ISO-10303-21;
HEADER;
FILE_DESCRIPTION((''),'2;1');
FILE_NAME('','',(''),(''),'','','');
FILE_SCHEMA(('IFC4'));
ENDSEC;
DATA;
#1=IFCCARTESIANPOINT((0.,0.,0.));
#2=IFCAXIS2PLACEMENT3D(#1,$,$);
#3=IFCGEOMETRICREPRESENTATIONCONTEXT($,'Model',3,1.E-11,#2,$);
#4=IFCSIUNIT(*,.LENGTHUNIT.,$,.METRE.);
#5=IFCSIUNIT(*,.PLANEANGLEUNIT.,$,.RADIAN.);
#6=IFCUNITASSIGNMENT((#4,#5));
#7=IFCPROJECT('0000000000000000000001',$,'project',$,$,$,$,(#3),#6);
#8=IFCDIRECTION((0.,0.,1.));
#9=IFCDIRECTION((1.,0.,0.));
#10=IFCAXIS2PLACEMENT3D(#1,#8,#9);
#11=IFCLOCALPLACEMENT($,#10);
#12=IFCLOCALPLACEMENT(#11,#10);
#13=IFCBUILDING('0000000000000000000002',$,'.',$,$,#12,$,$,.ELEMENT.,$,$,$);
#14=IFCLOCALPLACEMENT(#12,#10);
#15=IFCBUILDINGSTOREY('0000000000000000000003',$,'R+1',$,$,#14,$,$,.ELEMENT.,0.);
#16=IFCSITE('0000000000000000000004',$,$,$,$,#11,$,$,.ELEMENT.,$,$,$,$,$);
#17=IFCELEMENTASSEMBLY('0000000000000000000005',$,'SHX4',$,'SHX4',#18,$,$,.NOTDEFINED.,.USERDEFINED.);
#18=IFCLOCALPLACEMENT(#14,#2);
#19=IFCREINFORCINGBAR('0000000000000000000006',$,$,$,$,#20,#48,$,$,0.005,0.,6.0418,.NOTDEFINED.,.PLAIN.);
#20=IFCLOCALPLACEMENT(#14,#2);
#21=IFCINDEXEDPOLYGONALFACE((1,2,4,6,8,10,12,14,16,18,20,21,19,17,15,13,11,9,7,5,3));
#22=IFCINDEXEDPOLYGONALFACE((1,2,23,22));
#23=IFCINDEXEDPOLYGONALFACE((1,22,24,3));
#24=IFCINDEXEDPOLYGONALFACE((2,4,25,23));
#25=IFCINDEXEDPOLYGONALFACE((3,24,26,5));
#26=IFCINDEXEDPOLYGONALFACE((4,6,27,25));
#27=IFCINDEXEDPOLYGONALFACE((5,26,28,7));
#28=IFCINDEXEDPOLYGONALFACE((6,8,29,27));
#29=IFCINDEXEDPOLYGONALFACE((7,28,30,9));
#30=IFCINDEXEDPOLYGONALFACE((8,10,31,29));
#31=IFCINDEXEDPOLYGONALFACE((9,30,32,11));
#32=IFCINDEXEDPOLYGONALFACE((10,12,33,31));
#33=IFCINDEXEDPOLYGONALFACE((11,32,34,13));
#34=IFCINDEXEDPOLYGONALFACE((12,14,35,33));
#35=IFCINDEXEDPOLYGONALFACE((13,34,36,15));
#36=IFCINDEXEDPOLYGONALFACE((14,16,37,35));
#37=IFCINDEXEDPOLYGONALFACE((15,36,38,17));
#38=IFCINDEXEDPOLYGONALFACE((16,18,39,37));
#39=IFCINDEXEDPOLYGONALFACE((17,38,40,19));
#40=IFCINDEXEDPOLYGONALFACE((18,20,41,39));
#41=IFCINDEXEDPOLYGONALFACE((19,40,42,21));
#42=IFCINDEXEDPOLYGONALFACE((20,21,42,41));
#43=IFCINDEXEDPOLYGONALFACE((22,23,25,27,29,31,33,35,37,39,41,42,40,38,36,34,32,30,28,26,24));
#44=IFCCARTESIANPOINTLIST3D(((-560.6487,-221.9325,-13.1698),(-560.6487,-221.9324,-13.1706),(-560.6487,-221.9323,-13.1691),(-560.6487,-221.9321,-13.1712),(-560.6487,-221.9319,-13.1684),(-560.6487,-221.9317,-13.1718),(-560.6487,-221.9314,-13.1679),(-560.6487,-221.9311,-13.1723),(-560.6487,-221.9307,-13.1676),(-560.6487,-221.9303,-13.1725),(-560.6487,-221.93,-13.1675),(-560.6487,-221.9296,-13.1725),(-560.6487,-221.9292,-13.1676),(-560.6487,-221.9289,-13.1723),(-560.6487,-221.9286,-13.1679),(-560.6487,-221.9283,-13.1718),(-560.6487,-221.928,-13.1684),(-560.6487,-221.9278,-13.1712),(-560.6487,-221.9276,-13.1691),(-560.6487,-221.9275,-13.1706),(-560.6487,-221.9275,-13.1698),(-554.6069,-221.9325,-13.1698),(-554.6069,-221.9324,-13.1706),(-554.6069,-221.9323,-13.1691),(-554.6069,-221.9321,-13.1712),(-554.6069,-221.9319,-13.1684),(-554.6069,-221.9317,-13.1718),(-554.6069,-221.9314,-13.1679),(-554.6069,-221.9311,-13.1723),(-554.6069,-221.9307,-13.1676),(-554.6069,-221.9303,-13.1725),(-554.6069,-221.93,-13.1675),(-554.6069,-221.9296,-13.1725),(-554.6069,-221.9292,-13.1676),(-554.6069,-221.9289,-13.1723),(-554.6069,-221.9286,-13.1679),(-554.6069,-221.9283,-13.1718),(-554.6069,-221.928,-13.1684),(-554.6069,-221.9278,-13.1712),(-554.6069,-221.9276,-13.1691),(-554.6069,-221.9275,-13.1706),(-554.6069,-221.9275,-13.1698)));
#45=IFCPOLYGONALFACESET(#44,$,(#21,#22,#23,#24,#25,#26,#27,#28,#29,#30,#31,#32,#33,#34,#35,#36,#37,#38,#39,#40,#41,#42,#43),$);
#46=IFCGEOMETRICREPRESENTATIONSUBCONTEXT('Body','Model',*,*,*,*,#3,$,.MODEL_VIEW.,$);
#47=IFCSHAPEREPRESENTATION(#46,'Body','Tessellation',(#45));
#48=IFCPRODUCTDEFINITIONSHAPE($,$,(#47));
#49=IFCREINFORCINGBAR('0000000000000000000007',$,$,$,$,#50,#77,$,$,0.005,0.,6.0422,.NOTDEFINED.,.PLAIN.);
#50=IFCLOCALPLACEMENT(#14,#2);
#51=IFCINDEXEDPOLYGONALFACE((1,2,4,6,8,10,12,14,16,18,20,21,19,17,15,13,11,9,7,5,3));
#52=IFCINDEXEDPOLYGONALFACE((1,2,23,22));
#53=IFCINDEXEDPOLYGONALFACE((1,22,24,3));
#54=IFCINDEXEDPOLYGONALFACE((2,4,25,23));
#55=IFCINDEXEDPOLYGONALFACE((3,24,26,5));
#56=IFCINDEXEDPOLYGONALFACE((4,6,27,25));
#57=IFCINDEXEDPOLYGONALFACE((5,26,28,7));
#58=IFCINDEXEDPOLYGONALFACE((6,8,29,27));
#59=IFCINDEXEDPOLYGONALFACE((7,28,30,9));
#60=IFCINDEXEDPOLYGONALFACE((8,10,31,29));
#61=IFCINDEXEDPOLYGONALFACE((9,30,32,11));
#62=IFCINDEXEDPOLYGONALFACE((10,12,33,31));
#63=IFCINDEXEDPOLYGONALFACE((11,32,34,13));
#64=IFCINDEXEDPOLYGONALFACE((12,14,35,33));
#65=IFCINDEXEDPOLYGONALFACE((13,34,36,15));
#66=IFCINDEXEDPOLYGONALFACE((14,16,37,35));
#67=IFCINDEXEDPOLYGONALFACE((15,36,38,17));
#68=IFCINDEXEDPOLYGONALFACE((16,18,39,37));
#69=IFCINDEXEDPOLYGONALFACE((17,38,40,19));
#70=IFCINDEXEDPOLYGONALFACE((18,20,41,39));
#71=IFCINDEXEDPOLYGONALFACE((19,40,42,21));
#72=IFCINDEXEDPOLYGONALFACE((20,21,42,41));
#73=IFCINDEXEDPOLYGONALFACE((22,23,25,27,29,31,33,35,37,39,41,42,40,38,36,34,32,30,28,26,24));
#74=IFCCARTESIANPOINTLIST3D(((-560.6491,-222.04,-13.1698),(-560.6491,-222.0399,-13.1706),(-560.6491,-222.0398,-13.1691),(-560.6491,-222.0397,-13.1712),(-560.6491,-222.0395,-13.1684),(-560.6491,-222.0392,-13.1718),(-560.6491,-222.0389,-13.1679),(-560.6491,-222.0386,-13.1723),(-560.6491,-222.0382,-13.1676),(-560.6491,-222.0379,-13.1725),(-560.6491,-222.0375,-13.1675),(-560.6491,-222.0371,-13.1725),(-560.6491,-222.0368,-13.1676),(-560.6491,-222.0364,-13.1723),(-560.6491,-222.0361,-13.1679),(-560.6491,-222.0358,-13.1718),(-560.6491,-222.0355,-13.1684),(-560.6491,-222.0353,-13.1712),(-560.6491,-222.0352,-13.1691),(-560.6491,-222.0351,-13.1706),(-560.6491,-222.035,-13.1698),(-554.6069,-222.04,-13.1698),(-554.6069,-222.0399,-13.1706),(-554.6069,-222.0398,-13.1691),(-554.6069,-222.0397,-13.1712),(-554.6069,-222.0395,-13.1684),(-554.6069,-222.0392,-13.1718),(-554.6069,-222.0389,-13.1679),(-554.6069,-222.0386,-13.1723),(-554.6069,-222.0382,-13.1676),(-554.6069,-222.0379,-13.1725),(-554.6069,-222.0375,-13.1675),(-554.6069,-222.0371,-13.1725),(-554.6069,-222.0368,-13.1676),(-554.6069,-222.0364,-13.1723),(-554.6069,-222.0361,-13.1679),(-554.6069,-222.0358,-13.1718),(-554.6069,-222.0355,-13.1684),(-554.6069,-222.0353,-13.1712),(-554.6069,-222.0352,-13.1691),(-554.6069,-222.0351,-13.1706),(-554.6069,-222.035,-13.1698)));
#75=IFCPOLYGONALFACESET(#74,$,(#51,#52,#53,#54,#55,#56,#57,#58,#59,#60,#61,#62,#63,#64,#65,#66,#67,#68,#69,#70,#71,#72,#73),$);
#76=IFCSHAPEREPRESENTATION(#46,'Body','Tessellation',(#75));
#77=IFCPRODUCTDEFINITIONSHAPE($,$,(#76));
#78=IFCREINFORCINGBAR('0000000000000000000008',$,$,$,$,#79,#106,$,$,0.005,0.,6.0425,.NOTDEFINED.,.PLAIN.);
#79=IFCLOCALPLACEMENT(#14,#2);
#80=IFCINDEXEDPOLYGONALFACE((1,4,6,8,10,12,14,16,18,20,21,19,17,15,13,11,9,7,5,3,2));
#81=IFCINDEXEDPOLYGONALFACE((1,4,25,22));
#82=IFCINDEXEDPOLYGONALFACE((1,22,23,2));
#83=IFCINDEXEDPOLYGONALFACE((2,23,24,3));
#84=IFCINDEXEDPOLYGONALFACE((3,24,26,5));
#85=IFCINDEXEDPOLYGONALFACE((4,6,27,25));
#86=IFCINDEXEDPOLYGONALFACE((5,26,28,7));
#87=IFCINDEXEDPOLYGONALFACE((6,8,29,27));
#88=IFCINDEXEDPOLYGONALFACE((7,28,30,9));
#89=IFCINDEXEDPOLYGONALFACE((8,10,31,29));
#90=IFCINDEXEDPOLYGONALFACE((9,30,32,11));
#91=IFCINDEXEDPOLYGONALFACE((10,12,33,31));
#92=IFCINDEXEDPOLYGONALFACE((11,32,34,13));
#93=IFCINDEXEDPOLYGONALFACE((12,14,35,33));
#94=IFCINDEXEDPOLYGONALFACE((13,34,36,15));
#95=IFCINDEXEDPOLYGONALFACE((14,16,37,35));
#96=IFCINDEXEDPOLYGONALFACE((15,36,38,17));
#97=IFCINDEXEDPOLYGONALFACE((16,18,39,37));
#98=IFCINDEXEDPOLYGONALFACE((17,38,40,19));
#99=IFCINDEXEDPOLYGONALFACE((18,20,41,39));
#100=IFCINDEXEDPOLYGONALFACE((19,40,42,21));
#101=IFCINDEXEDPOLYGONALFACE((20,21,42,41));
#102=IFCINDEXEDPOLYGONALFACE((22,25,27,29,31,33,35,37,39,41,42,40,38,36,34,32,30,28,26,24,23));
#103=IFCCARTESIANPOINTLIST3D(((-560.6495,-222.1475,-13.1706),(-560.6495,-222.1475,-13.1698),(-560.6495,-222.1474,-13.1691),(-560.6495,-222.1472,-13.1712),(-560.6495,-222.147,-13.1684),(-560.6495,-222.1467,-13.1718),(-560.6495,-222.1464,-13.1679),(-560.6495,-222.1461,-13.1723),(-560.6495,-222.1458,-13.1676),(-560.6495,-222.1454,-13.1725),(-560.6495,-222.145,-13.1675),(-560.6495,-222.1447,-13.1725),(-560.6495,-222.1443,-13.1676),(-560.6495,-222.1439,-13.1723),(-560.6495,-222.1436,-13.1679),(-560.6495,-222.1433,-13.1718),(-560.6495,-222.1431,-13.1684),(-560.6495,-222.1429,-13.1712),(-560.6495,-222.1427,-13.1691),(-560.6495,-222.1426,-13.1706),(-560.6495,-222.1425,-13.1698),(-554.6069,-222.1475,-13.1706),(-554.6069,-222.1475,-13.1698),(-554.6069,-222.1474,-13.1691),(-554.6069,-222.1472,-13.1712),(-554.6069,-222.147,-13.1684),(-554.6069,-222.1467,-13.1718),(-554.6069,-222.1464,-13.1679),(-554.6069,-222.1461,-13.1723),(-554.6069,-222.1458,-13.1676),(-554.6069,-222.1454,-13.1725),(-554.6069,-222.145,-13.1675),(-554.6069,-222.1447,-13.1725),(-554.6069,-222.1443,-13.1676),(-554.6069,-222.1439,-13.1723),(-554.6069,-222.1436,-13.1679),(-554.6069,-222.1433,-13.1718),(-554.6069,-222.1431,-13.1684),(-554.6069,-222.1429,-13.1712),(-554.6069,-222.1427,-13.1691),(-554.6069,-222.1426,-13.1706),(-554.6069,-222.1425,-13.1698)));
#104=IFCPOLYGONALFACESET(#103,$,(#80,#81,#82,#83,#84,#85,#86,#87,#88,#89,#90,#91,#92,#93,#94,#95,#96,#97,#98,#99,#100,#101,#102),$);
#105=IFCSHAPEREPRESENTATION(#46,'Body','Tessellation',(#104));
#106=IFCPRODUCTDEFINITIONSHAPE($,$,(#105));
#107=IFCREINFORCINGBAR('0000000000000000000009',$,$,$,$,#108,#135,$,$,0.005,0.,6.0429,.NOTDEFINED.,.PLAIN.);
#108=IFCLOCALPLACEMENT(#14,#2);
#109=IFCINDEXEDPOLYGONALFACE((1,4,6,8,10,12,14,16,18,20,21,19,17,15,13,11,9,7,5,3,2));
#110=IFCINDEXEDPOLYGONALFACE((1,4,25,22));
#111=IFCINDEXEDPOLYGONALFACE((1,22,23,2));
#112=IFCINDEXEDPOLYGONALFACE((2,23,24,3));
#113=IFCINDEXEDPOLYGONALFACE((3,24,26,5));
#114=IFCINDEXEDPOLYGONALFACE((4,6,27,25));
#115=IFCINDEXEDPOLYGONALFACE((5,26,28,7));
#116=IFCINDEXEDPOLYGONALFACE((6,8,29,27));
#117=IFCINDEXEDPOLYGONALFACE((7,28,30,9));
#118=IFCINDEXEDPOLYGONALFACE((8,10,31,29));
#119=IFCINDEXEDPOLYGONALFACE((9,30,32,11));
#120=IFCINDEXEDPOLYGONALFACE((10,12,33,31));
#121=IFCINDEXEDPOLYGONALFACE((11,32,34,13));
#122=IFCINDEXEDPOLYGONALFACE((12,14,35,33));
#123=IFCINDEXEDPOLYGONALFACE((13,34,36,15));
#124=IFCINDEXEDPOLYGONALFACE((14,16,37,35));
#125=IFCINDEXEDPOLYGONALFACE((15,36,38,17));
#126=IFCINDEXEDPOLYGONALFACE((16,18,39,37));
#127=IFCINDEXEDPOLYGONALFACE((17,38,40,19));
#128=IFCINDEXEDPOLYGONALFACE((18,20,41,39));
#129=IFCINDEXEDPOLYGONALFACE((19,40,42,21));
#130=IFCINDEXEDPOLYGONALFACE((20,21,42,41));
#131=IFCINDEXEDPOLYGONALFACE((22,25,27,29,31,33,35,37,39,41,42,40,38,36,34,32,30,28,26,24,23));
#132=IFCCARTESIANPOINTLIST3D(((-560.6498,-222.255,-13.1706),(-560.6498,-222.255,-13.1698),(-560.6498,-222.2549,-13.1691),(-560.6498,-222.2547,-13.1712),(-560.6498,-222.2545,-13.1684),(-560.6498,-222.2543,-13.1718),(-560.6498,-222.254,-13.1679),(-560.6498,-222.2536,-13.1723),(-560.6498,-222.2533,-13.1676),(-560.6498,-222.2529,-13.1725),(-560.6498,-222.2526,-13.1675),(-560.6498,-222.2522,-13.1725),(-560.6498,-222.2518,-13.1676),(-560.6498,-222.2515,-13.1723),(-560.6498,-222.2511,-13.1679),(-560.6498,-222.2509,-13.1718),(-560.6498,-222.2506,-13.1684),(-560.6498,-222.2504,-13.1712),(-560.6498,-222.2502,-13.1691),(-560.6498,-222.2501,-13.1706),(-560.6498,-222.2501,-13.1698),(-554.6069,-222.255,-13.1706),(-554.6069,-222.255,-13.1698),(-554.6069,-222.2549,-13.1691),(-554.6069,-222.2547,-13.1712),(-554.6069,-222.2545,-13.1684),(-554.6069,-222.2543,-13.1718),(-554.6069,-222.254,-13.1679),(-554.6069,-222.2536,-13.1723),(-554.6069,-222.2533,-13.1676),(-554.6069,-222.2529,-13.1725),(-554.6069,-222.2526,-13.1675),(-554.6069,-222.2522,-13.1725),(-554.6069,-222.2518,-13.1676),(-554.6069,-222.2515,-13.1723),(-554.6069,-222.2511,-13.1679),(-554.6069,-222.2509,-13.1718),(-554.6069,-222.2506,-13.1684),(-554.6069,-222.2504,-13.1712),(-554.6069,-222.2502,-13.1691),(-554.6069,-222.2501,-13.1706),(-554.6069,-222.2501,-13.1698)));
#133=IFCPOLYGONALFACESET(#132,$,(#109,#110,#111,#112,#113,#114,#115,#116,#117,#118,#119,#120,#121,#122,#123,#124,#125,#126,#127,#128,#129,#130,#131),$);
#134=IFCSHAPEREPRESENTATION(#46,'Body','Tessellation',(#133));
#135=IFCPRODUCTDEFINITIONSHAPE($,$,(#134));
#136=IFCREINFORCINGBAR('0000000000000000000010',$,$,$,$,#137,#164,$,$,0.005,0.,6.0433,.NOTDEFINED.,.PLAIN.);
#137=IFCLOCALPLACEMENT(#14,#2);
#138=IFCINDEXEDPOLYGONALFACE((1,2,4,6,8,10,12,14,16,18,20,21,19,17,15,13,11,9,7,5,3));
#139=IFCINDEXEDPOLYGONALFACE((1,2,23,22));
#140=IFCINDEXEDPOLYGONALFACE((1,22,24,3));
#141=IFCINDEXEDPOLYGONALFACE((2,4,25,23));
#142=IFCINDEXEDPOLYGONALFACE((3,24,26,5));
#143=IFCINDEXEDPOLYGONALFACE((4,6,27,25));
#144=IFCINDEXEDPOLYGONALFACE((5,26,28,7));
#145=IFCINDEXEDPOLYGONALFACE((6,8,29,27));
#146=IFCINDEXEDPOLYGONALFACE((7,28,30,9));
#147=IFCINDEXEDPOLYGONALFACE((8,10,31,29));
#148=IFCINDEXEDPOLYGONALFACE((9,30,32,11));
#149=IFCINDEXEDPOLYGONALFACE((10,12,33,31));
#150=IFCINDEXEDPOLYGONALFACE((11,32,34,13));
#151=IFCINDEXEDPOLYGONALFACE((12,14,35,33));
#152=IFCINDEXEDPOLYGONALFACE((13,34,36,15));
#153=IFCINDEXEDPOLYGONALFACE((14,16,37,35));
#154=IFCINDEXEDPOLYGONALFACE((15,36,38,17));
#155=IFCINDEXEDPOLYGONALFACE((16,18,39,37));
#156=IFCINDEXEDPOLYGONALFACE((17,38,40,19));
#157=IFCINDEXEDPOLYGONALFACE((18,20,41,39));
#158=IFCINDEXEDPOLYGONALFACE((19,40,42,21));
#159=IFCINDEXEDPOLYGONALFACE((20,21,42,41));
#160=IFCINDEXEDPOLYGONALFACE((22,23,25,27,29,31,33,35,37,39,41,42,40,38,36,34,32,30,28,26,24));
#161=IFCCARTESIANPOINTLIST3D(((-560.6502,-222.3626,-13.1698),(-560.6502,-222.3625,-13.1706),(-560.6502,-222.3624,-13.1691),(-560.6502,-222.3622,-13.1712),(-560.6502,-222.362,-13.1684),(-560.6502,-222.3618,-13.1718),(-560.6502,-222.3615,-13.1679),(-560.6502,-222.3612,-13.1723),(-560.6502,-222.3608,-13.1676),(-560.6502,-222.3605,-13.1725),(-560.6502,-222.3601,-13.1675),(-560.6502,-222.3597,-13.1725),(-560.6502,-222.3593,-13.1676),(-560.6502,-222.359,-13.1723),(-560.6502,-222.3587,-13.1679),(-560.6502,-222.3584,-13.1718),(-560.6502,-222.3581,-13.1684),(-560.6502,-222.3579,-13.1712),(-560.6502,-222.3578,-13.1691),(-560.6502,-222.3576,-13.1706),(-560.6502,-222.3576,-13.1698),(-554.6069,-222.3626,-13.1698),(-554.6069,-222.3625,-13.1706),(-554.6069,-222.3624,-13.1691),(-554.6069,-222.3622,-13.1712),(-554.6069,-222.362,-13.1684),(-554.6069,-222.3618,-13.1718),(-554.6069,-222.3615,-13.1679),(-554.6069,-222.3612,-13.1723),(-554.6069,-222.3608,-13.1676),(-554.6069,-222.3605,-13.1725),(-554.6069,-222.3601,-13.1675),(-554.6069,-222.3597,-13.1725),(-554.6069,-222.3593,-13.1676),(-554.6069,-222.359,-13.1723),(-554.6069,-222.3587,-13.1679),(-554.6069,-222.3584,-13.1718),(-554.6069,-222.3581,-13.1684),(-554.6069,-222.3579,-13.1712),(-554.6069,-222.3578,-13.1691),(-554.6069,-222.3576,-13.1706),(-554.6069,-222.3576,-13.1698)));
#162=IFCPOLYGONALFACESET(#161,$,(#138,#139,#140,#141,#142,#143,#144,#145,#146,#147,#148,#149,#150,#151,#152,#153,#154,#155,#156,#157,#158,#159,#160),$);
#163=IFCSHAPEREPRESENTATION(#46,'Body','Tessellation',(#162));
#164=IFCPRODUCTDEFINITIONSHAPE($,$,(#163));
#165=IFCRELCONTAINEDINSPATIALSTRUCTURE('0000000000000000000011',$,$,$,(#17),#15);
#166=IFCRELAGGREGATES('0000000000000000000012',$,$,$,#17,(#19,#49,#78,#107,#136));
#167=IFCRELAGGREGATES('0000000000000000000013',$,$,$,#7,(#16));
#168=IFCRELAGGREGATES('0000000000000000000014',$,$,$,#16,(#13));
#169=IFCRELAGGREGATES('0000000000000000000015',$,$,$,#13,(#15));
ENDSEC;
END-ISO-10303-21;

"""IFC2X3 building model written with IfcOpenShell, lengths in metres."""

from ifc_helpers import new_model, entity, si_unit, origin, origin_with_axes, place, context, subcontext, project, spatial, shape, element, aggregate, save


model = new_model("IFC2X3")

# Units and contexts
model_context = context("Model", 3, precision=1e-11, world=origin())
body_context = subcontext(model_context, "Body", "Model", "MODEL_VIEW")
ifc_project = project(units=[si_unit("LENGTHUNIT", "METRE"), si_unit("PLANEANGLEUNIT", "RADIAN")], contexts=[model_context])

# Site, building, storey
site_placement = place(None, origin_with_axes())
site = spatial("IfcSite", under=ifc_project, at=site_placement, CompositionType="ELEMENT")
building_placement = place(site_placement, origin_with_axes())
building = spatial("IfcBuilding", under=site, at=building_placement, Name=".", CompositionType="ELEMENT")
storey_placement = place(building_placement, origin_with_axes())
storey = spatial("IfcBuildingStorey", under=building, at=storey_placement, Name="R+1", CompositionType="ELEMENT", Elevation=0.0)

# Element assembly, reinforcing bars
assembly_1_placement = place(storey_placement, origin_with_axes())
assembly_1 = element("IfcElementAssembly", 1, at=assembly_1_placement, inside=storey, Name="SHX4", ObjectType="SHX4", AssemblyPlace="NOTDEFINED", PredefinedType="USERDEFINED")
reinforcing_bar_1_placement = place(assembly_1_placement, origin_with_axes())
reinforcing_bar_1 = element("IfcReinforcingBar", 2, at=reinforcing_bar_1_placement, BarLength=6.0418, BarRole="NOTDEFINED", BarSurface="PLAIN", CrossSectionArea=0.0, NominalDiameter=0.005, shapes=[
    shape(body_context, "Body", "AdvancedSweptSolid", [entity("IfcSweptDiskSolid", entity("IfcPolyline", [entity("IfcCartesianPoint", [554.6069, 221.93, 13.17]), entity("IfcCartesianPoint", [560.6487, 221.93, 13.17])]), 0.0025, None, 0.0, 6.0418)]),
    shape(body_context, "Body", "AdvancedSweptSolid", [entity("IfcSweptDiskSolid", entity("IfcPolyline", [entity("IfcCartesianPoint", [554.6069, 221.93, 13.17]), entity("IfcCartesianPoint", [560.6487, 221.93, 13.17])]), 0.0025, None, 0.0, 6.0418)]),
])
reinforcing_bar_2_placement = place(assembly_1_placement, origin_with_axes())
reinforcing_bar_2 = element("IfcReinforcingBar", 3, at=reinforcing_bar_2_placement, BarLength=6.0422, BarRole="NOTDEFINED", BarSurface="PLAIN", CrossSectionArea=0.0, NominalDiameter=0.005, shapes=[
    shape(body_context, "Body", "AdvancedSweptSolid", [entity("IfcSweptDiskSolid", entity("IfcPolyline", [entity("IfcCartesianPoint", [554.6069, 222.0375, 13.17]), entity("IfcCartesianPoint", [560.6491, 222.0375, 13.17])]), 0.0025, None, 0.0, 6.0422)]),
    shape(body_context, "Body", "AdvancedSweptSolid", [entity("IfcSweptDiskSolid", entity("IfcPolyline", [entity("IfcCartesianPoint", [554.6069, 222.0375, 13.17]), entity("IfcCartesianPoint", [560.6491, 222.0375, 13.17])]), 0.0025, None, 0.0, 6.0422)]),
])
reinforcing_bar_3_placement = place(assembly_1_placement, origin_with_axes())
reinforcing_bar_3 = element("IfcReinforcingBar", 4, at=reinforcing_bar_3_placement, BarLength=6.0425, BarRole="NOTDEFINED", BarSurface="PLAIN", CrossSectionArea=0.0, NominalDiameter=0.005, shapes=[
    shape(body_context, "Body", "AdvancedSweptSolid", [entity("IfcSweptDiskSolid", entity("IfcPolyline", [entity("IfcCartesianPoint", [554.6069, 222.145, 13.17]), entity("IfcCartesianPoint", [560.6495, 222.145, 13.17])]), 0.0025, None, 0.0, 6.0425)]),
    shape(body_context, "Body", "AdvancedSweptSolid", [entity("IfcSweptDiskSolid", entity("IfcPolyline", [entity("IfcCartesianPoint", [554.6069, 222.145, 13.17]), entity("IfcCartesianPoint", [560.6495, 222.145, 13.17])]), 0.0025, None, 0.0, 6.0425)]),
])
reinforcing_bar_4_placement = place(assembly_1_placement, origin_with_axes())
reinforcing_bar_4 = element("IfcReinforcingBar", 5, at=reinforcing_bar_4_placement, BarLength=6.0429, BarRole="NOTDEFINED", BarSurface="PLAIN", CrossSectionArea=0.0, NominalDiameter=0.005, shapes=[
    shape(body_context, "Body", "AdvancedSweptSolid", [entity("IfcSweptDiskSolid", entity("IfcPolyline", [entity("IfcCartesianPoint", [554.6069, 222.2526, 13.17]), entity("IfcCartesianPoint", [560.6498, 222.2526, 13.17])]), 0.0025, None, 0.0, 6.0429)]),
    shape(body_context, "Body", "AdvancedSweptSolid", [entity("IfcSweptDiskSolid", entity("IfcPolyline", [entity("IfcCartesianPoint", [554.6069, 222.2526, 13.17]), entity("IfcCartesianPoint", [560.6498, 222.2526, 13.17])]), 0.0025, None, 0.0, 6.0429)]),
])
reinforcing_bar_5_placement = place(assembly_1_placement, origin_with_axes())
reinforcing_bar_5 = element("IfcReinforcingBar", 6, at=reinforcing_bar_5_placement, BarLength=6.0433, BarRole="NOTDEFINED", BarSurface="PLAIN", CrossSectionArea=0.0, NominalDiameter=0.005, shapes=[
    shape(body_context, "Body", "AdvancedSweptSolid", [entity("IfcSweptDiskSolid", entity("IfcPolyline", [entity("IfcCartesianPoint", [554.6069, 222.3601, 13.17]), entity("IfcCartesianPoint", [560.6502, 222.3601, 13.17])]), 0.0025, None, 0.0, 6.0433)]),
    shape(body_context, "Body", "AdvancedSweptSolid", [entity("IfcSweptDiskSolid", entity("IfcPolyline", [entity("IfcCartesianPoint", [554.6069, 222.3601, 13.17]), entity("IfcCartesianPoint", [560.6502, 222.3601, 13.17])]), 0.0025, None, 0.0, 6.0433)]),
])
aggregate(assembly_1, [reinforcing_bar_1, reinforcing_bar_2, reinforcing_bar_3, reinforcing_bar_4, reinforcing_bar_5])

save(model, "model.ifc")
